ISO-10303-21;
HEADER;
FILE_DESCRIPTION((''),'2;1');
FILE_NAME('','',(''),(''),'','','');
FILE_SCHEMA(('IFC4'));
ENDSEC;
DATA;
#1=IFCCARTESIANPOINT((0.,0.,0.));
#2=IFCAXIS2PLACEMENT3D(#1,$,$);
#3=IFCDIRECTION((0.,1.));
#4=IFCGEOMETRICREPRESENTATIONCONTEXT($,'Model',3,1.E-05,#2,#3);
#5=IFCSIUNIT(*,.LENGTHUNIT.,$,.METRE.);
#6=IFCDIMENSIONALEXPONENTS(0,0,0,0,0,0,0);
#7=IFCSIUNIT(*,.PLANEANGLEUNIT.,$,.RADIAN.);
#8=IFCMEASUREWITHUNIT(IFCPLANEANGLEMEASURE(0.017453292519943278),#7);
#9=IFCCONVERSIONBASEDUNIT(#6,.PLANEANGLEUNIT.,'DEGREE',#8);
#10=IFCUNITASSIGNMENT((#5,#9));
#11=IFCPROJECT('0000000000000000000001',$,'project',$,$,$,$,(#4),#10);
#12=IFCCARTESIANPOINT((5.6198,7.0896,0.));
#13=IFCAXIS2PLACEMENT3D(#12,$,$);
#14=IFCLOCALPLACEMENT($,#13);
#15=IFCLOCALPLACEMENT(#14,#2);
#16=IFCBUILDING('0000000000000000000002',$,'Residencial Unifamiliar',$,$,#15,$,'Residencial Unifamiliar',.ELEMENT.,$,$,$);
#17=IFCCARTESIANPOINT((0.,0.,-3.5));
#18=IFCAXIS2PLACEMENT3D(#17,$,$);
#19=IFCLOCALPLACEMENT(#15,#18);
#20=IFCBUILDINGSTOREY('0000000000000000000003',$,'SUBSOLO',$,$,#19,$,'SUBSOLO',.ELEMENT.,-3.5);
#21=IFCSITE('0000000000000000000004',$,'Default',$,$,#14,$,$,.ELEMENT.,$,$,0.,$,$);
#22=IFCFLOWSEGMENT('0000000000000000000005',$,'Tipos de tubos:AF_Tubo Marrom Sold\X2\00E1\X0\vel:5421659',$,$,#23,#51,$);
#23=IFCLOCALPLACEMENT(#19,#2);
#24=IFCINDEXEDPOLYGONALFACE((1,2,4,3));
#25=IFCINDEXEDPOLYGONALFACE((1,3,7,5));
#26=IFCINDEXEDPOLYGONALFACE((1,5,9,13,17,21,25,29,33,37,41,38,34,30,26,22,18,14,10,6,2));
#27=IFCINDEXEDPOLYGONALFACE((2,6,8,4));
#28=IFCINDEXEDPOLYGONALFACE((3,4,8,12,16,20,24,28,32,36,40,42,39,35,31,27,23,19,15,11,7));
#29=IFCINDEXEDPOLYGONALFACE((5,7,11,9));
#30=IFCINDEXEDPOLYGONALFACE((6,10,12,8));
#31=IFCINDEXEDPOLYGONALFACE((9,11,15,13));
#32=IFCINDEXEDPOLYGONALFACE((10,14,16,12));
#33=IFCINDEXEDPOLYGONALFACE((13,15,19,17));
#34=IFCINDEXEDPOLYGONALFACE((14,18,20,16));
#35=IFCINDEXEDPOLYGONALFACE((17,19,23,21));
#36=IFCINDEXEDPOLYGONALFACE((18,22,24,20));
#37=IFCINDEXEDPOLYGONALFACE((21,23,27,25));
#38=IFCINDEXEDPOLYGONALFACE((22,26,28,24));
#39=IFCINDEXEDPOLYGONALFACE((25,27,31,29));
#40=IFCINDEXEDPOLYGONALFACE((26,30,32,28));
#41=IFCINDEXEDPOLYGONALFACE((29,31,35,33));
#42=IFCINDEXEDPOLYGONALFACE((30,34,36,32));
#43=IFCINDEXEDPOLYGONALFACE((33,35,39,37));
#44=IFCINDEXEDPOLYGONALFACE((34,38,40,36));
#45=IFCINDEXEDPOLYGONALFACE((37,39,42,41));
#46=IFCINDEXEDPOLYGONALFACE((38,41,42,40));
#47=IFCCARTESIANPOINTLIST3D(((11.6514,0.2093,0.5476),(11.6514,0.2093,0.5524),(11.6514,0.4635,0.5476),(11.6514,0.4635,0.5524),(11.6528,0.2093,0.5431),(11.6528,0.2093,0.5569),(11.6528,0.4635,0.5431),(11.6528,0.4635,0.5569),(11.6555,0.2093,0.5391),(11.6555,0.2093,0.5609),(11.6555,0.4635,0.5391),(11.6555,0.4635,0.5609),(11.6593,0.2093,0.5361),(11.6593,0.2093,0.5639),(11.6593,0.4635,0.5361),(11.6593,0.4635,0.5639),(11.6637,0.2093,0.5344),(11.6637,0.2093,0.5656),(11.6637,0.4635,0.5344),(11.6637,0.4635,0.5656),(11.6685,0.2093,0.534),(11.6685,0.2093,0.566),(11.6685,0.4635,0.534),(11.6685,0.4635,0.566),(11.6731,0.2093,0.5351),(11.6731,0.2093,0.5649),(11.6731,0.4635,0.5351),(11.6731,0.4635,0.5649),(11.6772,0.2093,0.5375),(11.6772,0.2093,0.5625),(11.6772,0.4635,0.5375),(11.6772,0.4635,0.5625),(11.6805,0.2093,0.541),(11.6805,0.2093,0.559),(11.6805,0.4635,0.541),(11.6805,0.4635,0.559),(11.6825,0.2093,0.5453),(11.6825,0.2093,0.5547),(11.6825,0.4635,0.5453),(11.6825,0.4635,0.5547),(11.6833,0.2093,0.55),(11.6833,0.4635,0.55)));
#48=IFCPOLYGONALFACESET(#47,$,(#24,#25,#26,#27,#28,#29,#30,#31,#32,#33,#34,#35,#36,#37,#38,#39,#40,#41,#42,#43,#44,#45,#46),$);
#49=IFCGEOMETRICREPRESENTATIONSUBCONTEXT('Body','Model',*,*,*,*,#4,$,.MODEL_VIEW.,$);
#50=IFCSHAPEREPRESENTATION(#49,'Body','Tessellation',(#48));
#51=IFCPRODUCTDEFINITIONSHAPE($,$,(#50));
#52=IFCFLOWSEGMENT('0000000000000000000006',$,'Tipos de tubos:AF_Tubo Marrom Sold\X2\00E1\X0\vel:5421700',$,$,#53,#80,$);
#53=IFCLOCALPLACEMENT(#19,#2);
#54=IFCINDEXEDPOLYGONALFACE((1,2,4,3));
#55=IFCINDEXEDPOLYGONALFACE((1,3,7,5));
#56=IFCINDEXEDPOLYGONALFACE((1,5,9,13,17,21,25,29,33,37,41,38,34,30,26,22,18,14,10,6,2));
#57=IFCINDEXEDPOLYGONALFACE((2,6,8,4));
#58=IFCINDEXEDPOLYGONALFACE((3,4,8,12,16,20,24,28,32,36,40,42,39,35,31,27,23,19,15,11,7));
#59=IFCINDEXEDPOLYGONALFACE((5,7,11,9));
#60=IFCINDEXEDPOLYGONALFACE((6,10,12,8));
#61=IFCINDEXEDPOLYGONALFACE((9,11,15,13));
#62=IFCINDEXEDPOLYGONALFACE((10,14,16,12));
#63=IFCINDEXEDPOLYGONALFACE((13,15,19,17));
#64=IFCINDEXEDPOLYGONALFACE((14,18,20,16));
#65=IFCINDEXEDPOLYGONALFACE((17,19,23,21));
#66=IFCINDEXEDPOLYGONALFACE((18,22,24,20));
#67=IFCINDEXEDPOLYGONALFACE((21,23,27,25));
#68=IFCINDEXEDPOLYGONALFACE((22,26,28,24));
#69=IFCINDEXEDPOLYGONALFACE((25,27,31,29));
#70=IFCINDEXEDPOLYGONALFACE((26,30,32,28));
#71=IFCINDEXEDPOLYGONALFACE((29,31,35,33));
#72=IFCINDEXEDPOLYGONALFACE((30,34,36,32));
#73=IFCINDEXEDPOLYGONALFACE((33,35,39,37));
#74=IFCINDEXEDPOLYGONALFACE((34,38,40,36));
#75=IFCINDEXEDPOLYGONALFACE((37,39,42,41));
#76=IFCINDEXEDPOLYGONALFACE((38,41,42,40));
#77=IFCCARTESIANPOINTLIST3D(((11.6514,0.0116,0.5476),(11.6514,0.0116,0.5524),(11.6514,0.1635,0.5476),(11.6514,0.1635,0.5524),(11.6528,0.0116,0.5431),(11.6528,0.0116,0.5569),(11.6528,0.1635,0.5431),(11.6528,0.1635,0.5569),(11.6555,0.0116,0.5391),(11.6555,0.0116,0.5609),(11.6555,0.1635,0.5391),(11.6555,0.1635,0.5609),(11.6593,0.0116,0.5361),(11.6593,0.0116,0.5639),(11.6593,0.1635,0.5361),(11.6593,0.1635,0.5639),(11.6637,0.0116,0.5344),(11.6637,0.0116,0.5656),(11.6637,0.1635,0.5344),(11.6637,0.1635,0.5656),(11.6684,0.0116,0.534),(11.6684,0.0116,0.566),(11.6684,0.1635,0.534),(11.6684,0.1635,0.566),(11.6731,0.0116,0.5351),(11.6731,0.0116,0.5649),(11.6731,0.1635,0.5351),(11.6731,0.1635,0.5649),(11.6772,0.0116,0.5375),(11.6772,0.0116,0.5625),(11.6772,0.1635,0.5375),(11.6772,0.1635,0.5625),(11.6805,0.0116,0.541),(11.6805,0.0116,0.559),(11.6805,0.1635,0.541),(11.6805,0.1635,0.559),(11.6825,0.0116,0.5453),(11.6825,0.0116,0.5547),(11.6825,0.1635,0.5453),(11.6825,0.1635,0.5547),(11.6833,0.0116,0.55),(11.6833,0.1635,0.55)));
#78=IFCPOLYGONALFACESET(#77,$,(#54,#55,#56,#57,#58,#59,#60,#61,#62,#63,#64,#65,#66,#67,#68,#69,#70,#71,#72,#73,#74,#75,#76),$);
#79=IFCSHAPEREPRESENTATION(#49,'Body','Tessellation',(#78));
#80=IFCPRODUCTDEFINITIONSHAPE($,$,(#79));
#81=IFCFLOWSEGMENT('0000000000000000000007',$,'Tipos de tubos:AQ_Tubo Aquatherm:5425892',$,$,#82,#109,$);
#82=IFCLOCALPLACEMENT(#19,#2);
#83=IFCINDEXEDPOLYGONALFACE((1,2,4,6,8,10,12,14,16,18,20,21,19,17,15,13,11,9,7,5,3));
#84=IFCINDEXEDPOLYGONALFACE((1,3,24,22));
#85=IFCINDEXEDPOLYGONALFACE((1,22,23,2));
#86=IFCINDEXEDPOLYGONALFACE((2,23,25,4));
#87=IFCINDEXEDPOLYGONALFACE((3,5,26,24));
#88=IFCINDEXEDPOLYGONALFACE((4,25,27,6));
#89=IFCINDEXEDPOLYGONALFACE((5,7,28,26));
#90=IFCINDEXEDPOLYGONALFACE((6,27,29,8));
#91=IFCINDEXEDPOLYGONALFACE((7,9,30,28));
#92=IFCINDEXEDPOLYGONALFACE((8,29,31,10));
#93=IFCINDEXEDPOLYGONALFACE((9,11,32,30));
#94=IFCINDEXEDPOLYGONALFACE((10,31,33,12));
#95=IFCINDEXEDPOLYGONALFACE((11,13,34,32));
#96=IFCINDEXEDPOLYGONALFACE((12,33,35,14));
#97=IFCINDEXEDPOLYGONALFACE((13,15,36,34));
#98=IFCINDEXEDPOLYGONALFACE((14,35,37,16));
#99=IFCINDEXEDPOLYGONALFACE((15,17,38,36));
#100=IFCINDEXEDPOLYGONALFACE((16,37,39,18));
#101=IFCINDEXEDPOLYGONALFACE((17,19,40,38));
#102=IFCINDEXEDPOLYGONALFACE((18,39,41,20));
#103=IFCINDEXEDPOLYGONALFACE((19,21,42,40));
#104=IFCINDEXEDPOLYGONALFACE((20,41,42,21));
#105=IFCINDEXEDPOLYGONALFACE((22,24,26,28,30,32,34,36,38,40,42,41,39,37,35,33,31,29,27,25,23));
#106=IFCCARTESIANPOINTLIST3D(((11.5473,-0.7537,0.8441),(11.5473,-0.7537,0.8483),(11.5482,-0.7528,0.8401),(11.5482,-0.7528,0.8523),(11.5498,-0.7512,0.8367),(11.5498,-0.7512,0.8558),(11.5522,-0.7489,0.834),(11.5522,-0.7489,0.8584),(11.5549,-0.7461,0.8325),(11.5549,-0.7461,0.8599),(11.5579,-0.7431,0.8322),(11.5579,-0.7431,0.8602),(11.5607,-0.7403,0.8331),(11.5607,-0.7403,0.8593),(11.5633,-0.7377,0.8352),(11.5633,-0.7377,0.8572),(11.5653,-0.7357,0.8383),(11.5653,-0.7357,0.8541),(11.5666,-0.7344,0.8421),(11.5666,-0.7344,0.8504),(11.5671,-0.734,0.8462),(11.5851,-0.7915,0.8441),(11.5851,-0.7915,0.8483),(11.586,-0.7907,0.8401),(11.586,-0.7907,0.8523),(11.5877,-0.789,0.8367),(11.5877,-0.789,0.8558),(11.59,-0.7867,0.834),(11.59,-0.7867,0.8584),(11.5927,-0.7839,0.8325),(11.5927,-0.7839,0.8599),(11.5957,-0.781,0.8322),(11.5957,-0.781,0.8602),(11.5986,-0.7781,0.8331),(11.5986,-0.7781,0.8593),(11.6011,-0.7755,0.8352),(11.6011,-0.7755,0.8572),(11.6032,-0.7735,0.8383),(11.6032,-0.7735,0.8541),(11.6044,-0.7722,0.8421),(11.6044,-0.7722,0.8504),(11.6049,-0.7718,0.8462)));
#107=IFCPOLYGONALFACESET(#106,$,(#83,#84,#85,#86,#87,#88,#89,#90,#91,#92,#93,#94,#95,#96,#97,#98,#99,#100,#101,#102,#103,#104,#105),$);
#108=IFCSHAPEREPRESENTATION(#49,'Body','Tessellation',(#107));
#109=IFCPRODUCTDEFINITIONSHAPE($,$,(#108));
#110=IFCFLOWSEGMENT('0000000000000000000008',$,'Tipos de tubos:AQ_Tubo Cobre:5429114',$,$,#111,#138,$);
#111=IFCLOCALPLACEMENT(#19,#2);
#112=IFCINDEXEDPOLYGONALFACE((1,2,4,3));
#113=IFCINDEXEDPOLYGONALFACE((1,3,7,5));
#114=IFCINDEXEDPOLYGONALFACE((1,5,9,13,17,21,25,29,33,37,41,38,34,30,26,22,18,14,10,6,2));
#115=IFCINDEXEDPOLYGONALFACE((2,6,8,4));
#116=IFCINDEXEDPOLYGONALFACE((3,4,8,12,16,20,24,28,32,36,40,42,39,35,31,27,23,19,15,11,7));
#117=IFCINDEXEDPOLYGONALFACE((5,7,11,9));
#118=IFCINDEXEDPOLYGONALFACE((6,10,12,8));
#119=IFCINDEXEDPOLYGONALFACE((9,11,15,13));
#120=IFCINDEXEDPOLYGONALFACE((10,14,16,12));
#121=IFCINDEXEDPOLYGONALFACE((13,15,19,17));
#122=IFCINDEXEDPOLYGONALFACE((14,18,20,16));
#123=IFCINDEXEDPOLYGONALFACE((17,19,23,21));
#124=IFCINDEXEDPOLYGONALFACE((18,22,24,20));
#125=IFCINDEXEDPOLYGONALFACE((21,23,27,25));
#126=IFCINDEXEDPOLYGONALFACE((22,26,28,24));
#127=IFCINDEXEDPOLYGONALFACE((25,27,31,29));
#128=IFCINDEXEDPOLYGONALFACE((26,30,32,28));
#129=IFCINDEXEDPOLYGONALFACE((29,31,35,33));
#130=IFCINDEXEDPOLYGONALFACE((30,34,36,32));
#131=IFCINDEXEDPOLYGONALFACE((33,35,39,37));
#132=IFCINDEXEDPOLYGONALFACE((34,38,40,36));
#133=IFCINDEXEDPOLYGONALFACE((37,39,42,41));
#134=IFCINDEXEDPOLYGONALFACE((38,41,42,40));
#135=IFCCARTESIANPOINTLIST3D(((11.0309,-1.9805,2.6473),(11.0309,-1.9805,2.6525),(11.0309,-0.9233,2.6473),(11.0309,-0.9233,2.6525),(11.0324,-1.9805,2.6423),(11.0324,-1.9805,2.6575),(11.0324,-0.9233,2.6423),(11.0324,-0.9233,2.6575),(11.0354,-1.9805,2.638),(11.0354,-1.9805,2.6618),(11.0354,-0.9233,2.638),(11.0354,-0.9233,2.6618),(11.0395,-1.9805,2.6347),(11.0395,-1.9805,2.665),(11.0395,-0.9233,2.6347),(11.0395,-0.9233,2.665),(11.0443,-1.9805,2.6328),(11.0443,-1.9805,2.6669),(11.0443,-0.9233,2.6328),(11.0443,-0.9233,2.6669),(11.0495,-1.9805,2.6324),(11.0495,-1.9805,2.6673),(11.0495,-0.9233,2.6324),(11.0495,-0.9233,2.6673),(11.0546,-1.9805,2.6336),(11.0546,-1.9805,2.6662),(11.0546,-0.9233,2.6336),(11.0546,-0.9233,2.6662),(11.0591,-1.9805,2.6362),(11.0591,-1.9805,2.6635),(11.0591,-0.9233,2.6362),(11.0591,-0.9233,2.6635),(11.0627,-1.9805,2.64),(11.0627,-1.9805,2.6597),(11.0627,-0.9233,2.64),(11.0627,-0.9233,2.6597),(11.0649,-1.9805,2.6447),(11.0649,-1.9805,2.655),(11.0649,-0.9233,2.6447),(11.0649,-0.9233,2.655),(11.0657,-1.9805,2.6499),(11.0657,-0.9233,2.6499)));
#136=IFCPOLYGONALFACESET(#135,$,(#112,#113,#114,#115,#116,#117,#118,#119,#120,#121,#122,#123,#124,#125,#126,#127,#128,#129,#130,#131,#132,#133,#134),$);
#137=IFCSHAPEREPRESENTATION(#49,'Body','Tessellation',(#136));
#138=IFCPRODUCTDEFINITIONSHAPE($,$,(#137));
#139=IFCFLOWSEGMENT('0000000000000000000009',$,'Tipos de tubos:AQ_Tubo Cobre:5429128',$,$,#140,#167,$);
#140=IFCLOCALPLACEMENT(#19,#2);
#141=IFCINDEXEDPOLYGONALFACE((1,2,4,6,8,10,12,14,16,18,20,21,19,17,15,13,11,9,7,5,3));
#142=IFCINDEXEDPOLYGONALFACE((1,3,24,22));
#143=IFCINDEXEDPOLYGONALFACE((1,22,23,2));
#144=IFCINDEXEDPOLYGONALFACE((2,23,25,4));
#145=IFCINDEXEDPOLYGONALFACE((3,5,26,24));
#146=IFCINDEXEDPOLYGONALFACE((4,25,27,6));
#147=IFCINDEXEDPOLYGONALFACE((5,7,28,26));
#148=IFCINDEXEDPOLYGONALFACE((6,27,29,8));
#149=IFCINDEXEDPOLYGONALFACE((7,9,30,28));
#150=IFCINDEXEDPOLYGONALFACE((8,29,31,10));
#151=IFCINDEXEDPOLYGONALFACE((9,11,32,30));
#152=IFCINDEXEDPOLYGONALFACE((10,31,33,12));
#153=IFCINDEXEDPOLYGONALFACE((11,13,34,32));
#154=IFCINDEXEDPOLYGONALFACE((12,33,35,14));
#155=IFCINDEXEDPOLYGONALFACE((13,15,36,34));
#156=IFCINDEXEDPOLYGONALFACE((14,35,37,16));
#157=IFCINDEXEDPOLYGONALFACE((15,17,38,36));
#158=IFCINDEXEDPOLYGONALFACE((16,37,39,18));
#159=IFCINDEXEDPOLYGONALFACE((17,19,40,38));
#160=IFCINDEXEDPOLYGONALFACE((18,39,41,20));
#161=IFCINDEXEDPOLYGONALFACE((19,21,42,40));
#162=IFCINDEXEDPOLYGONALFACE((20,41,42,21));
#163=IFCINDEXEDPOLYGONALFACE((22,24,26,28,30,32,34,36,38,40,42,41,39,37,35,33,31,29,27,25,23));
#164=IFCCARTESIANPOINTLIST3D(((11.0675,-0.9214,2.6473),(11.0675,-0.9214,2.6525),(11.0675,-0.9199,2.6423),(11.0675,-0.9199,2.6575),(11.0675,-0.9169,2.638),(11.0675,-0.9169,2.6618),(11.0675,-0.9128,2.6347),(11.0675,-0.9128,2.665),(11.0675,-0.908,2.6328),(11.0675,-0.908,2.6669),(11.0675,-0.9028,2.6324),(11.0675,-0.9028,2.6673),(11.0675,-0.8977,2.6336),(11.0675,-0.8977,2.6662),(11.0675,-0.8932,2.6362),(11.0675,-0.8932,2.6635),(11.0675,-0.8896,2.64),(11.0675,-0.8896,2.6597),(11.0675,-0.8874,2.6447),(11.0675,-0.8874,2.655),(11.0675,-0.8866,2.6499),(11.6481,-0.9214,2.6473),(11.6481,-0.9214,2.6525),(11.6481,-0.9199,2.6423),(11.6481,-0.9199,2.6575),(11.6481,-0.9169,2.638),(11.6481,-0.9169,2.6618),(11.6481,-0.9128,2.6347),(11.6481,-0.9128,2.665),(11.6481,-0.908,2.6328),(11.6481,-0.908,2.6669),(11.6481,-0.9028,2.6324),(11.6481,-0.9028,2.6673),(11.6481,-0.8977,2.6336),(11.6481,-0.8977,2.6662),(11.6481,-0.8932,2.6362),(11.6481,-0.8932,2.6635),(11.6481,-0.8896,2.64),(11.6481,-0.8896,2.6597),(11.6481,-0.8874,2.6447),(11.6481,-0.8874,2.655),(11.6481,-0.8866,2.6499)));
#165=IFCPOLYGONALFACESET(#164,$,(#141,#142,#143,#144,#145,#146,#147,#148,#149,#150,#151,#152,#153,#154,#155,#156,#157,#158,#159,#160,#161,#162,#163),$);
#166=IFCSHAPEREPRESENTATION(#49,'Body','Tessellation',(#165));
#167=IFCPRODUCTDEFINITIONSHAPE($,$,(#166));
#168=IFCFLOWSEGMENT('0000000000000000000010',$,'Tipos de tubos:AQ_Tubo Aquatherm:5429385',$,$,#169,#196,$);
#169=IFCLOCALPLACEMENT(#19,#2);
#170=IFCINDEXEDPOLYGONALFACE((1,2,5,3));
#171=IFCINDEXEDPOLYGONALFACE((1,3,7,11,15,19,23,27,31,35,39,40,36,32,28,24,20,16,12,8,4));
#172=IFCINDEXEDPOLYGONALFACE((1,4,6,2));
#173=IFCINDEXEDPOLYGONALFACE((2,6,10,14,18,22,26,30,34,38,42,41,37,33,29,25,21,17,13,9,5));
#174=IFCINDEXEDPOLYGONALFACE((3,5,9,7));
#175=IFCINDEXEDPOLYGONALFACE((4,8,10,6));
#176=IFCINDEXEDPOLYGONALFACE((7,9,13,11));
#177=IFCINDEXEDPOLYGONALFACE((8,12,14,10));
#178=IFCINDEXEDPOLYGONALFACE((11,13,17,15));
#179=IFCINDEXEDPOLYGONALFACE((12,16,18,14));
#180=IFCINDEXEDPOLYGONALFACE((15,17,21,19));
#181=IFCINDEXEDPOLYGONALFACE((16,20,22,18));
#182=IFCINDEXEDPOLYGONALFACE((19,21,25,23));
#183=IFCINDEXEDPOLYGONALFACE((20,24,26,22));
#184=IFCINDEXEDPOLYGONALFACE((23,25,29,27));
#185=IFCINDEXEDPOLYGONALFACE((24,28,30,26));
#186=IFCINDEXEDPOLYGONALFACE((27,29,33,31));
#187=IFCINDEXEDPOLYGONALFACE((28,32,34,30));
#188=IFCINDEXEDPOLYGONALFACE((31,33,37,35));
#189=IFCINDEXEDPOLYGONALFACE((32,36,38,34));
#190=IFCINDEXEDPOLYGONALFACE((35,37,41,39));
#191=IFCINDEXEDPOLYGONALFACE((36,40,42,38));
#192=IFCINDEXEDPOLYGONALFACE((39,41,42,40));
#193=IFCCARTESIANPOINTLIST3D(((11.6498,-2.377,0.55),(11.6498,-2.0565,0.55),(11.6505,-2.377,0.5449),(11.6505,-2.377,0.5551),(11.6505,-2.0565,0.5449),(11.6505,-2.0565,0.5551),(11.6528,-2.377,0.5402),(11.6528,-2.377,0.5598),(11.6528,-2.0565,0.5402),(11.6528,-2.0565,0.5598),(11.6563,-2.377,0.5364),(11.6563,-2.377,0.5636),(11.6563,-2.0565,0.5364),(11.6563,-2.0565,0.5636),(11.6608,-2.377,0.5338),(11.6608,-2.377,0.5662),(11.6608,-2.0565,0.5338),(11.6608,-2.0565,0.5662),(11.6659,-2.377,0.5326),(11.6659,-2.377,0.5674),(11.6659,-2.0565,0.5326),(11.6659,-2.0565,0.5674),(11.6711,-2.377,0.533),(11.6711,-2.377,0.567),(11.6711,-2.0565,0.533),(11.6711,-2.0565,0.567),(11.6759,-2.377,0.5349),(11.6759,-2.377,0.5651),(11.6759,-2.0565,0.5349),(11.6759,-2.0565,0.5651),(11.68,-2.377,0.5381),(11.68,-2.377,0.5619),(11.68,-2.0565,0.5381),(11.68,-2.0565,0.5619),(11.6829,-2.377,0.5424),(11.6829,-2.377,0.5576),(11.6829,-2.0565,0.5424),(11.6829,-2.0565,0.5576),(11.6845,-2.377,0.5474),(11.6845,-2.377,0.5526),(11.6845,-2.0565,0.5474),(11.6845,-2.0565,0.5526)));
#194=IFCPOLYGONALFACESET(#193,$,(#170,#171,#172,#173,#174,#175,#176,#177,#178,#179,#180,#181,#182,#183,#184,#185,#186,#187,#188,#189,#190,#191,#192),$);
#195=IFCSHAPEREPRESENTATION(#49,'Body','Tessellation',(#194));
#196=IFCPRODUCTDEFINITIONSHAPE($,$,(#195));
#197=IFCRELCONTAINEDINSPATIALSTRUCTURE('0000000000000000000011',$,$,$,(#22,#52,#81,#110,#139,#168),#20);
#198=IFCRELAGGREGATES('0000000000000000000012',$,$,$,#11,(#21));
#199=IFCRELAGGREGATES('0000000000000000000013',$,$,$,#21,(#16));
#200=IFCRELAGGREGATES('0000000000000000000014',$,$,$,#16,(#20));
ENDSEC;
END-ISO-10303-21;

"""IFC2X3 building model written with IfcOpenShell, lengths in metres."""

from ifc_helpers import new_model, entity, si_unit, converted_unit, direction, frame, frame_2d, origin, origin_2d_with_axis, place, context, subcontext, project, spatial, circle, extrude, element, save


model = new_model("IFC2X3")

# Units and contexts
model_context = context("Model", 3, precision=1e-05, world=origin(), true_north=direction((0.0, 1.0)))
body_context = subcontext(model_context, "Body", "Model", "MODEL_VIEW")
ifc_project = project(units=[si_unit("LENGTHUNIT", "METRE"), converted_unit("PLANEANGLEUNIT", "DEGREE", entity("IfcPlaneAngleMeasure", 0.017453292519943278), si_unit("PLANEANGLEUNIT", "RADIAN"), dimensions=[0, 0, 0, 0, 0, 0, 0])], contexts=[model_context])

# Site, building, storey
site_placement = place(None, frame((5.6198, 7.0896, 0.0)))
site = spatial("IfcSite", under=ifc_project, at=site_placement, Name="Default", CompositionType="ELEMENT", RefElevation=0.0)
building_placement = place(site_placement, origin())
building = spatial("IfcBuilding", under=site, at=building_placement, Name="Residencial Unifamiliar", LongName="Residencial Unifamiliar", CompositionType="ELEMENT")
storey_placement = place(building_placement, frame((0.0, 0.0, -3.5)))
storey = spatial("IfcBuildingStorey", under=building, at=storey_placement, Name="SUBSOLO", LongName="SUBSOLO", CompositionType="ELEMENT", Elevation=-3.5)

# Flow segments
flow_segment_1_placement = place(storey_placement, origin())
element("IfcFlowSegment", 1, at=flow_segment_1_placement, inside=storey, Name="Tipos de tubos:AF_Tubo Marrom Soldável:5421659", context=body_context, shape_type="SweptSolid", body=[
    extrude(circle(Radius=0.016, at=origin_2d_with_axis()), frame((11.6673, 0.2093, 0.55), z_axis=(0.0, 1.0, 0.0), x_axis=(1.0, 0.0, 0.0)), (0.0, 0.0, 1.0), 0.2542),
])
flow_segment_2_placement = place(storey_placement, origin())
element("IfcFlowSegment", 2, at=flow_segment_2_placement, inside=storey, Name="Tipos de tubos:AF_Tubo Marrom Soldável:5421700", context=body_context, shape_type="SweptSolid", body=[
    extrude(circle(Radius=0.016, at=frame_2d((0.0, 0.0), x_axis=(1.0, 0.0))), frame((11.6673, 0.0116, 0.55), z_axis=(0.0, 1.0, 0.0), x_axis=(1.0, 0.0, 0.0)), (0.0, 0.0, 1.0), 0.1519),
])
flow_segment_3_placement = place(storey_placement, origin())
element("IfcFlowSegment", 3, at=flow_segment_3_placement, inside=storey, Name="Tipos de tubos:AQ_Tubo Aquatherm:5425892", context=body_context, shape_type="SweptSolid", body=[
    extrude(circle(Radius=0.0141, at=origin_2d_with_axis()), frame((11.5949, -0.7817, 0.8462), z_axis=(-0.707107, 0.707107, 0.0), x_axis=(0.707107, 0.707107, 0.0)), (0.0, 0.0, 1.0), 0.0535),
])
flow_segment_4_placement = place(storey_placement, origin())
element("IfcFlowSegment", 4, at=flow_segment_4_placement, inside=storey, Name="Tipos de tubos:AQ_Tubo Cobre:5429114", context=body_context, shape_type="SweptSolid", body=[
    extrude(circle(Radius=0.0175, at=origin_2d_with_axis()), frame((11.0482, -1.9805, 2.6499), z_axis=(0.0, 1.0, 0.0), x_axis=(1.0, 0.0, 0.0)), (0.0, 0.0, 1.0), 1.0572),
])
flow_segment_5_placement = place(storey_placement, origin())
element("IfcFlowSegment", 5, at=flow_segment_5_placement, inside=storey, Name="Tipos de tubos:AQ_Tubo Cobre:5429128", context=body_context, shape_type="SweptSolid", body=[
    extrude(circle(Radius=0.0175, at=origin_2d_with_axis()), frame((11.0675, -0.9041, 2.6499), z_axis=(1.0, 0.0, 0.0), x_axis=(0.0, 1.0, 0.0)), (0.0, 0.0, 1.0), 0.5806),
])
flow_segment_6_placement = place(storey_placement, origin())
element("IfcFlowSegment", 6, at=flow_segment_6_placement, inside=storey, Name="Tipos de tubos:AQ_Tubo Aquatherm:5429385", context=body_context, shape_type="SweptSolid", body=[
    extrude(circle(Radius=0.0175, at=origin_2d_with_axis()), frame((11.6672, -2.377, 0.55), z_axis=(0.0, 1.0, 0.0), x_axis=(-1.0, 0.0, 0.0)), (0.0, 0.0, 1.0), 0.3205),
])

save(model, "model.ifc")
